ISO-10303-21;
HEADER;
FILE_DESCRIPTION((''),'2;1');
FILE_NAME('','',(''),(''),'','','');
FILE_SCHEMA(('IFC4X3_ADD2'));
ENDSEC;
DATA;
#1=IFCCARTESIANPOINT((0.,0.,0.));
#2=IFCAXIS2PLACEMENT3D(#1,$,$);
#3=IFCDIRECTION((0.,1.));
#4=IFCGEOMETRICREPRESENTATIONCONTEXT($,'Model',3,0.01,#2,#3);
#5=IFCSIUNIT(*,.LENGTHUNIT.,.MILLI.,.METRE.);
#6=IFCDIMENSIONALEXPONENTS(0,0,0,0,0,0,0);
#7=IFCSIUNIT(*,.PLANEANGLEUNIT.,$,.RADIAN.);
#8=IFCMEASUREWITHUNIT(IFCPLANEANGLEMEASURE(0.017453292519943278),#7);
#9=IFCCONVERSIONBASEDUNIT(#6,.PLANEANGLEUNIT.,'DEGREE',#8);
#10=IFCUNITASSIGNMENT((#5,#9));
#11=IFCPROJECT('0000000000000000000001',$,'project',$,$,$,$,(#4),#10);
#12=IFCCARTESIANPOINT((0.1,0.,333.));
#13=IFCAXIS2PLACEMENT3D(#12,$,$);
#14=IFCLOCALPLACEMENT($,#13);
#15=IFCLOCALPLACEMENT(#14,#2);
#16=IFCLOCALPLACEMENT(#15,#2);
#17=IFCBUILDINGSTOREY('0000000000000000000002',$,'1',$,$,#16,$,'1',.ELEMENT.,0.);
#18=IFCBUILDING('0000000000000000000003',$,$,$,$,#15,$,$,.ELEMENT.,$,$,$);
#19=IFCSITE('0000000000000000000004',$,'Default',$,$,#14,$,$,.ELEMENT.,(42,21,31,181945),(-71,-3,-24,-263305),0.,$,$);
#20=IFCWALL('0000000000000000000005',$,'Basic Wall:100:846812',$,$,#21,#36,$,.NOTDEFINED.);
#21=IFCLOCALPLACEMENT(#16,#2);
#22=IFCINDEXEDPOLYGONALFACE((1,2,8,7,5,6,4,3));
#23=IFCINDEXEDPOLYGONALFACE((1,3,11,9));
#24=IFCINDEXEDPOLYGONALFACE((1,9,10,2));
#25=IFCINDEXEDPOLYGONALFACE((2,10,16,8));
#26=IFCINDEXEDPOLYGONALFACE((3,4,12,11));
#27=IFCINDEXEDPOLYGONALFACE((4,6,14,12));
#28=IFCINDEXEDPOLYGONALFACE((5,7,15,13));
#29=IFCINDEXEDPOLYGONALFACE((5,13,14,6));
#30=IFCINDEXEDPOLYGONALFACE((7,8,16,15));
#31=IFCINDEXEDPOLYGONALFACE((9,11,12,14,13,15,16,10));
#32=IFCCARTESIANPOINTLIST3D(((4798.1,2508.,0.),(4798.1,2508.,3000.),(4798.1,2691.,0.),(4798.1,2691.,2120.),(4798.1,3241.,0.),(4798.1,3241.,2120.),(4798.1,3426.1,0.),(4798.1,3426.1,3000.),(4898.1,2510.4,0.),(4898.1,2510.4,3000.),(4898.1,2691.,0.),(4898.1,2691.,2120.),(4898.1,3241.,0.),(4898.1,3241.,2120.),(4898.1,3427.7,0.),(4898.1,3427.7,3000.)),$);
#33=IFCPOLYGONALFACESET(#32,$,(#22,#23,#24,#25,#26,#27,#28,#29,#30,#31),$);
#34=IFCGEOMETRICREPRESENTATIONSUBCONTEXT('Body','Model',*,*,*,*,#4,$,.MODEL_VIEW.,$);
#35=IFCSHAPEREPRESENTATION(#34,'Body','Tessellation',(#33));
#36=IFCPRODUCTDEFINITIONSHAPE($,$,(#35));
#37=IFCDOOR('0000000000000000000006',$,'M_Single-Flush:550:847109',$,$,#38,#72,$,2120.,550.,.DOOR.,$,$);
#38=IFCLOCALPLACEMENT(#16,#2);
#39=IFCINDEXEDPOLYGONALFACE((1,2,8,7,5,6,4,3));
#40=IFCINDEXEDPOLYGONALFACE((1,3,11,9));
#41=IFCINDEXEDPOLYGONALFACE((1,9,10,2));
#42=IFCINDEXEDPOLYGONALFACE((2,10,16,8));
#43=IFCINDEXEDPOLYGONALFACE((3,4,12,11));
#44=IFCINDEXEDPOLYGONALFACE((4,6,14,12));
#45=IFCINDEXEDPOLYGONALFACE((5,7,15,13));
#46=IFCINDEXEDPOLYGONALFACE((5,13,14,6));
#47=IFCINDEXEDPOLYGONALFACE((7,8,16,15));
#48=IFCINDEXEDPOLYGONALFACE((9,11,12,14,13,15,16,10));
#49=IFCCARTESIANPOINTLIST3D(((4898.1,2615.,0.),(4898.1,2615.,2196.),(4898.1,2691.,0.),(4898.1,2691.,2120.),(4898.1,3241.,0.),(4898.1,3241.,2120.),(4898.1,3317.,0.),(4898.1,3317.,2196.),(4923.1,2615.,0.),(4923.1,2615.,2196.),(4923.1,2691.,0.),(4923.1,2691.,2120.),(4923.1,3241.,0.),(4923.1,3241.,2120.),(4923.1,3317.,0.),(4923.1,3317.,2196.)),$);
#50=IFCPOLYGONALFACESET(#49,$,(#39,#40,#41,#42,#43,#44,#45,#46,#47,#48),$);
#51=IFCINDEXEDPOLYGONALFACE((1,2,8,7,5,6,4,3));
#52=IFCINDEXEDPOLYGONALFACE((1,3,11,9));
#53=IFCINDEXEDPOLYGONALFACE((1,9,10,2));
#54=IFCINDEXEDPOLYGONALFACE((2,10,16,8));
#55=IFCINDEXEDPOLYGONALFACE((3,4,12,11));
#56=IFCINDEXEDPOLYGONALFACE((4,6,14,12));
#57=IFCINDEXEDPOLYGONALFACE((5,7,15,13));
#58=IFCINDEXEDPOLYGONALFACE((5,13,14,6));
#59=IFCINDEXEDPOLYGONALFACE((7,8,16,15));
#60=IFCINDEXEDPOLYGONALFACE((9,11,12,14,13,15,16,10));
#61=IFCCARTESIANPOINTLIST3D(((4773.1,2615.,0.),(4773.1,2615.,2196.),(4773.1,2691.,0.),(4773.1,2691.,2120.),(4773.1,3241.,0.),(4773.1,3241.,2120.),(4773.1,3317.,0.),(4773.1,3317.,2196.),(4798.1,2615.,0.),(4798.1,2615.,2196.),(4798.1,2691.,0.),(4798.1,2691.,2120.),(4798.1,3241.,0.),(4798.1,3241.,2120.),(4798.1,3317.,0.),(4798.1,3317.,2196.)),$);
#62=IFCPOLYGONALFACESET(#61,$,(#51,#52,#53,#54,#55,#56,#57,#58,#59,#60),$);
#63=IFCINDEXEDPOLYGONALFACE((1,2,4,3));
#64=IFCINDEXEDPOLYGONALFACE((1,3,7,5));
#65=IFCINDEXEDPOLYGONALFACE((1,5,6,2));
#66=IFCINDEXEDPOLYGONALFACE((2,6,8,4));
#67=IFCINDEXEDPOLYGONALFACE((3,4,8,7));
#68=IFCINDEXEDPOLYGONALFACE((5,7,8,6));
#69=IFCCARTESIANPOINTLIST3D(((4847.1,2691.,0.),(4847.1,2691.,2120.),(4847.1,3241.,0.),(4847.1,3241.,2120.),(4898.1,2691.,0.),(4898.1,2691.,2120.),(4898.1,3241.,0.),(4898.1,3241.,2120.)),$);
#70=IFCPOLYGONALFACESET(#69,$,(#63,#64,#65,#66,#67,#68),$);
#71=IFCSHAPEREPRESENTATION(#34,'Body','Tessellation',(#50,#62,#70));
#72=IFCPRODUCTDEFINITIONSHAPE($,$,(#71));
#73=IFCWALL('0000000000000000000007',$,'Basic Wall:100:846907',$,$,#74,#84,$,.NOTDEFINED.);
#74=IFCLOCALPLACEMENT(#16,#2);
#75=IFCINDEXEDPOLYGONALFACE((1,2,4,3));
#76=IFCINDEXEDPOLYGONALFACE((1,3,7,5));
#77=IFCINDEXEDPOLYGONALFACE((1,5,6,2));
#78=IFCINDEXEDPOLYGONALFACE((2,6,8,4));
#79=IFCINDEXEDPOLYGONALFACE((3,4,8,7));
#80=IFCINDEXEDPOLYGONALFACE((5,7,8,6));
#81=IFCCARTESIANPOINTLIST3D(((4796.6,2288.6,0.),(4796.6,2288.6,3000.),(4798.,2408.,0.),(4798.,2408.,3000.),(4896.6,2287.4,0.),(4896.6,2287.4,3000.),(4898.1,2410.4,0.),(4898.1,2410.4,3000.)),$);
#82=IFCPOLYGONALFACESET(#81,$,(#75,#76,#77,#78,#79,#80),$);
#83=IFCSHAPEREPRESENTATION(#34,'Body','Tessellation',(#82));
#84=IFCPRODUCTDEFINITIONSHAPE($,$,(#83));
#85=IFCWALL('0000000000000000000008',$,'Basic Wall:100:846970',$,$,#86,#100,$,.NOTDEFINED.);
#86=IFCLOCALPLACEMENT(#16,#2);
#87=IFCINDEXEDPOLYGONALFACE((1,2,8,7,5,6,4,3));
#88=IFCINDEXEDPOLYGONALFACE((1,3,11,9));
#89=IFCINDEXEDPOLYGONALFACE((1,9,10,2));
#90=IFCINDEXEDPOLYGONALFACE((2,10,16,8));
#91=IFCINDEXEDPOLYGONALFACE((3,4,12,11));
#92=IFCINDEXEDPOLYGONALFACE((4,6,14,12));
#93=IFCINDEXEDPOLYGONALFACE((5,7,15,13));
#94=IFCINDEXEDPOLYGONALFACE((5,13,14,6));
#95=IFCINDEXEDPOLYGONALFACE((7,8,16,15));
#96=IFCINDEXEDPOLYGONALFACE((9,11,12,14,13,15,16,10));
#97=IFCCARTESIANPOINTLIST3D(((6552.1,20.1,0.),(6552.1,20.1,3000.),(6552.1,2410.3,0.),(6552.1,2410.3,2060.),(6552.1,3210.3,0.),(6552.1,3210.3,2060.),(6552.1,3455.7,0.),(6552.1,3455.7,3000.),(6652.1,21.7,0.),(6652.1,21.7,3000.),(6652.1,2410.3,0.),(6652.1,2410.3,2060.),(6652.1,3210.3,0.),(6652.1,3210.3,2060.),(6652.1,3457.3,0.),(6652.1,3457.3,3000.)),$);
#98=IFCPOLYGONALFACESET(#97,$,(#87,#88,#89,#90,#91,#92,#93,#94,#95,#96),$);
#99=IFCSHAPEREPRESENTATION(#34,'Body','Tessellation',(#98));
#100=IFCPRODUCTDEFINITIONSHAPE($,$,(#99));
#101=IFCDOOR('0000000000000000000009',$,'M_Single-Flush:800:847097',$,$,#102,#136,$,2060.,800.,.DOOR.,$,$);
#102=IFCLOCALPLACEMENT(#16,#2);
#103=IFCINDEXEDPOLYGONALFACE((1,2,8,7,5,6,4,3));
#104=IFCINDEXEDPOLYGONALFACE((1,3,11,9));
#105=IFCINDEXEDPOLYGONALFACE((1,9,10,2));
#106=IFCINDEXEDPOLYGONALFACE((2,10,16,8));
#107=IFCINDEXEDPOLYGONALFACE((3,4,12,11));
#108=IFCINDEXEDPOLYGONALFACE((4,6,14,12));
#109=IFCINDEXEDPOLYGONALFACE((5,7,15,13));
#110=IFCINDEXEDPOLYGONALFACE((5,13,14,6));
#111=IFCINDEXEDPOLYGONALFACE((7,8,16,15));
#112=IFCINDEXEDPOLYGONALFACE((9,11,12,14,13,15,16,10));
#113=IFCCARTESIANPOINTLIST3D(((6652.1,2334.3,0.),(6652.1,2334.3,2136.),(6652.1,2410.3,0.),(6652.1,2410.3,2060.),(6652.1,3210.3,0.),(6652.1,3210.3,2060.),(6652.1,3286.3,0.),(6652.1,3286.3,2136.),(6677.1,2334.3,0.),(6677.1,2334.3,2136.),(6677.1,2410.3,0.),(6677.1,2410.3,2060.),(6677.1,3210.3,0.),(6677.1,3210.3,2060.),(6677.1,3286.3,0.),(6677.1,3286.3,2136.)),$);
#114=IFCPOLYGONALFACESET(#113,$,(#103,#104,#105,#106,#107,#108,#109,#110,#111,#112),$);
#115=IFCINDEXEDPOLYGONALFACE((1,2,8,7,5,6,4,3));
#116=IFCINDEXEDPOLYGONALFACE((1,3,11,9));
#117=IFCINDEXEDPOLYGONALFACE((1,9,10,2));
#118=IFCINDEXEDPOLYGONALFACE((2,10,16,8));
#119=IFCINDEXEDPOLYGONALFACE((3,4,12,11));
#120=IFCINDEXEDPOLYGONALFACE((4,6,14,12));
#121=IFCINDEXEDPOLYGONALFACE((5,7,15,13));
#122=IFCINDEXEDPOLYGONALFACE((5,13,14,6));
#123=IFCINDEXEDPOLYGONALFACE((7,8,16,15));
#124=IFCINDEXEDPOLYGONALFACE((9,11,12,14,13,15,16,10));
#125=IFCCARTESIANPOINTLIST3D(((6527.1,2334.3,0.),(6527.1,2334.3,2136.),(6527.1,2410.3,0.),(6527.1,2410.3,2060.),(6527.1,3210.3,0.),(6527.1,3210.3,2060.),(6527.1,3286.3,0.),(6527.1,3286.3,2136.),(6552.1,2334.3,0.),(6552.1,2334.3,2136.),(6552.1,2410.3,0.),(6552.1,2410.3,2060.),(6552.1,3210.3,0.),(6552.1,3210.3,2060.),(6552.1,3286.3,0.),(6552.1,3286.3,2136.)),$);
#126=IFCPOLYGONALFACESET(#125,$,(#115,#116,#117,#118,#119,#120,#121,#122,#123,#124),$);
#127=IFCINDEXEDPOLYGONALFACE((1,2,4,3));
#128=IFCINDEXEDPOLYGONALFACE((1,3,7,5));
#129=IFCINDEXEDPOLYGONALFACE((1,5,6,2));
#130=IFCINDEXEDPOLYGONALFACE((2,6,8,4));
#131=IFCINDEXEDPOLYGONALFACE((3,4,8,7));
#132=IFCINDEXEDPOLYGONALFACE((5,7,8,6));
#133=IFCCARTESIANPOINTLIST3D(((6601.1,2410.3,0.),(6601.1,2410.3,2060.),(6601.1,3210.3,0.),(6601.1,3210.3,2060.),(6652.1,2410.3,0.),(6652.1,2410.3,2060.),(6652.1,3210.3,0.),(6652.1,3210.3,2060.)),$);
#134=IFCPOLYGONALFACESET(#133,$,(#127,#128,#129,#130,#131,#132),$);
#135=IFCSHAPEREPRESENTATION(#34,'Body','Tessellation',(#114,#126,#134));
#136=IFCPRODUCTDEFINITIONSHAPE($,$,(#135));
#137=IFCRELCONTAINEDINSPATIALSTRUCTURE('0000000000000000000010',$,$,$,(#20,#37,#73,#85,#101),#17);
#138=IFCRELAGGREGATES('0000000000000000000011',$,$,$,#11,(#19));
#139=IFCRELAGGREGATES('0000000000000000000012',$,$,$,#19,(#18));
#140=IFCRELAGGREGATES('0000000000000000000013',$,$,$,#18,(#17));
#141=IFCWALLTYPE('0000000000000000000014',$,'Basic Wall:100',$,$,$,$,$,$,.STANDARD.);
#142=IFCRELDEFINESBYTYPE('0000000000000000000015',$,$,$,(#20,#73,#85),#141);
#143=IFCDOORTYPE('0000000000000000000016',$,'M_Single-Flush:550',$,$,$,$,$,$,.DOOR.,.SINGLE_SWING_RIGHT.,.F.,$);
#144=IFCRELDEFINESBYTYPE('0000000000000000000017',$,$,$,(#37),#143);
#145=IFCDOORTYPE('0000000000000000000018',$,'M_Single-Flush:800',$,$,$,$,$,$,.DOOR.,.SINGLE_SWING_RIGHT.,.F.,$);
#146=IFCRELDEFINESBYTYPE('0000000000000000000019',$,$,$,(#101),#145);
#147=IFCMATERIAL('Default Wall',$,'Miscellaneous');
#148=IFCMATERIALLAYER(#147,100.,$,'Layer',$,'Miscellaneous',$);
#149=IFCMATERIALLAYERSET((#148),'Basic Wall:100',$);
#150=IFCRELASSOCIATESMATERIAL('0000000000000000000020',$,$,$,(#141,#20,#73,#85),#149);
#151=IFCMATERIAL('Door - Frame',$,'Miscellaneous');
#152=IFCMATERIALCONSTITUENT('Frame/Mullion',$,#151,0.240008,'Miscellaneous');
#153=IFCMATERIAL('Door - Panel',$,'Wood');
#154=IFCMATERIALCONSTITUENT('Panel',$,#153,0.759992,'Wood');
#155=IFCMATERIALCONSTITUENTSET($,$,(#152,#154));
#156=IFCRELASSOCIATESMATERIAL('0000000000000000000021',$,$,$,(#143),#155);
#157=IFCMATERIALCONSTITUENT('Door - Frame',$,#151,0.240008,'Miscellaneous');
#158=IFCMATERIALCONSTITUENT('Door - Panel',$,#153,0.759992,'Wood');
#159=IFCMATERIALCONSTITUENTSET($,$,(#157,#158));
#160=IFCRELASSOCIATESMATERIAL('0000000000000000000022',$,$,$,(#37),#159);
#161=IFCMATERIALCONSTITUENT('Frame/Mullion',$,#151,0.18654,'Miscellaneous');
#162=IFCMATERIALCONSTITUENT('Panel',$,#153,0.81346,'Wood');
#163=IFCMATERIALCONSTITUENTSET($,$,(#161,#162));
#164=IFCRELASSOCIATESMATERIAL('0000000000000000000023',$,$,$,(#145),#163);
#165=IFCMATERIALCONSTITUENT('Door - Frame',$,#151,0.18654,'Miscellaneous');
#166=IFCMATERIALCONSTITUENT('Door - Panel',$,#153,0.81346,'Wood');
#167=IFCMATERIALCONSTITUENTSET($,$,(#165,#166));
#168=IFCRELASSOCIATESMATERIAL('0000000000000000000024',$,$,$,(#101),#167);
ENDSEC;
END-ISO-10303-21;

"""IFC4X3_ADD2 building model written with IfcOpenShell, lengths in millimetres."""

from ifc_helpers import new_model, entity, si_unit, converted_unit, direction, frame, frame_2d, origin, origin_2d_with_axis, place, context, subcontext, project, spatial, polyline, rectangle, outline, extrude, source, transform, mapped, material, layer, layer_set, constituent, constituent_set, type_object, type_shapes, element, fill, save


model = new_model("IFC4X3_ADD2")

# Units and contexts
model_context = context("Model", 3, precision=0.01, world=origin(), true_north=direction((0.0, 1.0)))
body_context = subcontext(model_context, "Body", "Model", "MODEL_VIEW")
ifc_project = project(units=[si_unit("LENGTHUNIT", "METRE", prefix="MILLI"), converted_unit("PLANEANGLEUNIT", "DEGREE", entity("IfcPlaneAngleMeasure", 0.017453292519943278), si_unit("PLANEANGLEUNIT", "RADIAN"), dimensions=[0, 0, 0, 0, 0, 0, 0])], contexts=[model_context])

# Site, building, storey
site_placement = place(None, frame((0.1, 0.0, 333.0)))
site = spatial("IfcSite", under=ifc_project, at=site_placement, Name="Default", CompositionType="ELEMENT", RefLatitude=(42, 21, 31, 181945), RefLongitude=(-71, -3, -24, -263305), RefElevation=0.0)
building_placement = place(site_placement, origin())
building = spatial("IfcBuilding", under=site, at=building_placement, CompositionType="ELEMENT")
storey_placement = place(building_placement, origin())
storey = spatial("IfcBuildingStorey", under=building, at=storey_placement, Name="1", LongName="1", CompositionType="ELEMENT", Elevation=0.0)

# Shared definitions
ifc_material_1 = material(Name="Default Wall", Category="Miscellaneous")

# Shared definitions
ifc_material_2 = material(Name="Door - Frame", Category="Miscellaneous")
ifc_material_3 = material(Name="Door - Panel", Category="Wood")

# Wall, opening, door
ifc_layer_1 = layer(ifc_material_1, 100.0, Name="Layer", Category="Miscellaneous")
ifc_layer_set_1 = layer_set([ifc_layer_1], Name="Basic Wall:100")
wall_type_1 = type_object("IfcWallType", Name="Basic Wall:100", PredefinedType="STANDARD", material=ifc_layer_set_1)
wall_1_placement = place(storey_placement, frame((4848.1, 2508.0, 0.0), z_axis=(0.0, 0.0, 1.0), x_axis=(0.0, 1.0, 0.0)))
wall_1 = element("IfcWall", 1, at=wall_1_placement, inside=storey, type_object=wall_type_1, material=ifc_layer_set_1, Name="Basic Wall:100:846812", PredefinedType="NOTDEFINED", context=body_context, shape_type="SweptSolid", body=[
    extrude(outline(polyline([(2.3, -50.0), (919.7, -50.0), (918.0, 50.0), (0.0, 50.0), (2.3, -50.0)])), origin(), (0.0, 0.0, 1.0), 3000.0),
])
opening_1_placement = place(wall_1_placement, frame((732.9, 50.0, 0.0)))
opening_1 = element("IfcOpeningElement", 2, at=opening_1_placement, cuts=wall_1, PredefinedType="OPENING", context=body_context, shape_type="SweptSolid", body=[
    extrude(rectangle(XDim=550.0, YDim=2120.0, at=frame_2d((1060.0, 275.0), x_axis=(0.0, 1.0))), frame((0.0, 0.0, 0.0), z_axis=(0.0, -1.0, 0.0), x_axis=(0.0, 0.0, 1.0)), (0.0, 0.0, 1.0), 100.0),
])
ifc_constituent_1 = constituent(ifc_material_2, Name="Door - Frame", Category="Miscellaneous", fraction=0.240008)
ifc_constituent_2 = constituent(ifc_material_3, Name="Door - Panel", Category="Wood", fraction=0.759992)
ifc_constituent_set_1 = constituent_set(constituents=[ifc_constituent_1, ifc_constituent_2])
ifc_constituent_3 = constituent(ifc_material_2, Name="Frame/Mullion", Category="Miscellaneous", fraction=0.240008)
ifc_constituent_4 = constituent(ifc_material_3, Name="Panel", Category="Wood", fraction=0.759992)
ifc_constituent_set_2 = constituent_set(constituents=[ifc_constituent_3, ifc_constituent_4])
door_type_1 = type_object("IfcDoorType", Name="M_Single-Flush:550", OperationType="SINGLE_SWING_RIGHT", ParameterTakesPrecedence=False, PredefinedType="DOOR", material=ifc_constituent_set_2)
shared_shape_1 = source(origin(), body_context, "Body", "SweptSolid", [
    extrude(outline(polyline([(-351.0, -1117.0), (351.0, -1117.0), (351.0, 1079.0), (275.0, 1079.0), (275.0, -1041.0), (-275.0, -1041.0), (-275.0, 1079.0), (-351.0, 1079.0), (-351.0, -1117.0)])), frame((275.0, 100.0, 1079.0), z_axis=(0.0, 1.0, 0.0), x_axis=(1.0, 0.0, 0.0)), (0.0, 0.0, 1.0), 25.0),
    extrude(outline(polyline([(-1117.0, -351.0), (1079.0, -351.0), (1079.0, -275.0), (-1041.0, -275.0), (-1041.0, 275.0), (1079.0, 275.0), (1079.0, 351.0), (-1117.0, 351.0), (-1117.0, -351.0)])), frame((275.0, -25.0, 1079.0), z_axis=(0.0, 1.0, 0.0), x_axis=(0.0, 0.0, -1.0)), (0.0, 0.0, 1.0), 25.0),
    extrude(rectangle(XDim=51.0, YDim=550.0, at=origin_2d_with_axis()), frame((275.0, 74.5, 0.0), z_axis=(0.0, 0.0, 1.0), x_axis=(0.0, 1.0, 0.0)), (0.0, 0.0, 1.0), 2120.0),
])
type_shapes(door_type_1, [shared_shape_1])
door_1_placement = place(opening_1_placement, frame((0.0, 0.0, 0.0), z_axis=(0.0, 0.0, 1.0), x_axis=(-1.0, 0.0, 0.0)))
door_1 = element("IfcDoor", 3, at=door_1_placement, inside=storey, type_object=door_type_1, material=ifc_constituent_set_1, Name="M_Single-Flush:550:847109", OverallHeight=2120.0, OverallWidth=550.0, PredefinedType="DOOR", context=body_context, shape_type="MappedRepresentation", body=[
    mapped(shared_shape_1, transform((0.0, 0.0, 0.0), scale=1.0)),
])
fill(opening_1, door_1)

# Wall
wall_2_placement = place(storey_placement, frame((4848.1, 2411.0, 0.0), z_axis=(0.0, 0.0, 1.0), x_axis=(-0.011924, -0.999929, 0.0)))
element("IfcWall", 4, at=wall_2_placement, inside=storey, type_object=wall_type_1, material=ifc_layer_set_1, Name="Basic Wall:100:846907", PredefinedType="NOTDEFINED", context=body_context, shape_type="SweptSolid", body=[
    extrude(outline(polyline([(122.9, -50.0), (122.9, 50.0), (0.0, 50.0), (3.5, -50.0), (122.9, -50.0)])), origin(), (0.0, 0.0, 1.0), 3000.0),
])

# Wall, opening, door
wall_3_placement = place(storey_placement, frame((6602.1, 3457.3, 0.0), z_axis=(0.0, 0.0, 1.0), x_axis=(0.0, -1.0, 0.0)))
wall_3 = element("IfcWall", 5, at=wall_3_placement, inside=storey, type_object=wall_type_1, material=ifc_layer_set_1, Name="Basic Wall:100:846970", PredefinedType="NOTDEFINED", context=body_context, shape_type="SweptSolid", body=[
    extrude(outline(polyline([(1.7, -50.0), (1899.0, -50.0), (1999.0, -50.0), (3437.2, -50.0), (3435.7, 50.0), (3036.9, 50.0), (2936.9, 50.0), (0.0, 50.0), (1.7, -50.0)])), origin(), (0.0, 0.0, 1.0), 3000.0),
])
opening_2_placement = place(wall_3_placement, frame((247.0, -50.0, 0.0)))
opening_2 = element("IfcOpeningElement", 6, at=opening_2_placement, cuts=wall_3, PredefinedType="OPENING", context=body_context, shape_type="SweptSolid", body=[
    extrude(rectangle(XDim=800.0, YDim=2060.0, at=frame_2d((1030.0, 400.0), x_axis=(0.0, 1.0))), frame((0.0, 0.0, 0.0), z_axis=(0.0, 1.0, 0.0), x_axis=(0.0, 0.0, 1.0)), (0.0, 0.0, 1.0), 100.0),
])
ifc_constituent_5 = constituent(ifc_material_2, Name="Door - Frame", Category="Miscellaneous", fraction=0.18654)
ifc_constituent_6 = constituent(ifc_material_3, Name="Door - Panel", Category="Wood", fraction=0.81346)
ifc_constituent_set_3 = constituent_set(constituents=[ifc_constituent_5, ifc_constituent_6])
ifc_constituent_7 = constituent(ifc_material_2, Name="Frame/Mullion", Category="Miscellaneous", fraction=0.18654)
ifc_constituent_8 = constituent(ifc_material_3, Name="Panel", Category="Wood", fraction=0.81346)
ifc_constituent_set_4 = constituent_set(constituents=[ifc_constituent_7, ifc_constituent_8])
door_type_2 = type_object("IfcDoorType", Name="M_Single-Flush:800", OperationType="SINGLE_SWING_RIGHT", ParameterTakesPrecedence=False, PredefinedType="DOOR", material=ifc_constituent_set_4)
shared_shape_2 = source(origin(), body_context, "Body", "SweptSolid", [
    extrude(outline(polyline([(-476.0, -1087.0), (476.0, -1087.0), (476.0, 1049.0), (400.0, 1049.0), (400.0, -1011.0), (-400.0, -1011.0), (-400.0, 1049.0), (-476.0, 1049.0), (-476.0, -1087.0)])), frame((400.0, 100.0, 1049.0), z_axis=(0.0, 1.0, 0.0), x_axis=(1.0, 0.0, 0.0)), (0.0, 0.0, 1.0), 25.0),
    extrude(outline(polyline([(-1087.0, -476.0), (1049.0, -476.0), (1049.0, -400.0), (-1011.0, -400.0), (-1011.0, 400.0), (1049.0, 400.0), (1049.0, 476.0), (-1087.0, 476.0), (-1087.0, -476.0)])), frame((400.0, -25.0, 1049.0), z_axis=(0.0, 1.0, 0.0), x_axis=(0.0, 0.0, -1.0)), (0.0, 0.0, 1.0), 25.0),
    extrude(rectangle(XDim=51.0, YDim=800.0, at=origin_2d_with_axis()), frame((400.0, 74.5, 0.0), z_axis=(0.0, 0.0, 1.0), x_axis=(0.0, 1.0, 0.0)), (0.0, 0.0, 1.0), 2060.0),
])
type_shapes(door_type_2, [shared_shape_2])
door_2_placement = place(opening_2_placement, origin())
door_2 = element("IfcDoor", 7, at=door_2_placement, inside=storey, type_object=door_type_2, material=ifc_constituent_set_3, Name="M_Single-Flush:800:847097", OverallHeight=2060.0, OverallWidth=800.0, PredefinedType="DOOR", context=body_context, shape_type="MappedRepresentation", body=[
    mapped(shared_shape_2, transform((0.0, 0.0, 0.0), scale=1.0)),
])
fill(opening_2, door_2)

save(model, "model.ifc")
